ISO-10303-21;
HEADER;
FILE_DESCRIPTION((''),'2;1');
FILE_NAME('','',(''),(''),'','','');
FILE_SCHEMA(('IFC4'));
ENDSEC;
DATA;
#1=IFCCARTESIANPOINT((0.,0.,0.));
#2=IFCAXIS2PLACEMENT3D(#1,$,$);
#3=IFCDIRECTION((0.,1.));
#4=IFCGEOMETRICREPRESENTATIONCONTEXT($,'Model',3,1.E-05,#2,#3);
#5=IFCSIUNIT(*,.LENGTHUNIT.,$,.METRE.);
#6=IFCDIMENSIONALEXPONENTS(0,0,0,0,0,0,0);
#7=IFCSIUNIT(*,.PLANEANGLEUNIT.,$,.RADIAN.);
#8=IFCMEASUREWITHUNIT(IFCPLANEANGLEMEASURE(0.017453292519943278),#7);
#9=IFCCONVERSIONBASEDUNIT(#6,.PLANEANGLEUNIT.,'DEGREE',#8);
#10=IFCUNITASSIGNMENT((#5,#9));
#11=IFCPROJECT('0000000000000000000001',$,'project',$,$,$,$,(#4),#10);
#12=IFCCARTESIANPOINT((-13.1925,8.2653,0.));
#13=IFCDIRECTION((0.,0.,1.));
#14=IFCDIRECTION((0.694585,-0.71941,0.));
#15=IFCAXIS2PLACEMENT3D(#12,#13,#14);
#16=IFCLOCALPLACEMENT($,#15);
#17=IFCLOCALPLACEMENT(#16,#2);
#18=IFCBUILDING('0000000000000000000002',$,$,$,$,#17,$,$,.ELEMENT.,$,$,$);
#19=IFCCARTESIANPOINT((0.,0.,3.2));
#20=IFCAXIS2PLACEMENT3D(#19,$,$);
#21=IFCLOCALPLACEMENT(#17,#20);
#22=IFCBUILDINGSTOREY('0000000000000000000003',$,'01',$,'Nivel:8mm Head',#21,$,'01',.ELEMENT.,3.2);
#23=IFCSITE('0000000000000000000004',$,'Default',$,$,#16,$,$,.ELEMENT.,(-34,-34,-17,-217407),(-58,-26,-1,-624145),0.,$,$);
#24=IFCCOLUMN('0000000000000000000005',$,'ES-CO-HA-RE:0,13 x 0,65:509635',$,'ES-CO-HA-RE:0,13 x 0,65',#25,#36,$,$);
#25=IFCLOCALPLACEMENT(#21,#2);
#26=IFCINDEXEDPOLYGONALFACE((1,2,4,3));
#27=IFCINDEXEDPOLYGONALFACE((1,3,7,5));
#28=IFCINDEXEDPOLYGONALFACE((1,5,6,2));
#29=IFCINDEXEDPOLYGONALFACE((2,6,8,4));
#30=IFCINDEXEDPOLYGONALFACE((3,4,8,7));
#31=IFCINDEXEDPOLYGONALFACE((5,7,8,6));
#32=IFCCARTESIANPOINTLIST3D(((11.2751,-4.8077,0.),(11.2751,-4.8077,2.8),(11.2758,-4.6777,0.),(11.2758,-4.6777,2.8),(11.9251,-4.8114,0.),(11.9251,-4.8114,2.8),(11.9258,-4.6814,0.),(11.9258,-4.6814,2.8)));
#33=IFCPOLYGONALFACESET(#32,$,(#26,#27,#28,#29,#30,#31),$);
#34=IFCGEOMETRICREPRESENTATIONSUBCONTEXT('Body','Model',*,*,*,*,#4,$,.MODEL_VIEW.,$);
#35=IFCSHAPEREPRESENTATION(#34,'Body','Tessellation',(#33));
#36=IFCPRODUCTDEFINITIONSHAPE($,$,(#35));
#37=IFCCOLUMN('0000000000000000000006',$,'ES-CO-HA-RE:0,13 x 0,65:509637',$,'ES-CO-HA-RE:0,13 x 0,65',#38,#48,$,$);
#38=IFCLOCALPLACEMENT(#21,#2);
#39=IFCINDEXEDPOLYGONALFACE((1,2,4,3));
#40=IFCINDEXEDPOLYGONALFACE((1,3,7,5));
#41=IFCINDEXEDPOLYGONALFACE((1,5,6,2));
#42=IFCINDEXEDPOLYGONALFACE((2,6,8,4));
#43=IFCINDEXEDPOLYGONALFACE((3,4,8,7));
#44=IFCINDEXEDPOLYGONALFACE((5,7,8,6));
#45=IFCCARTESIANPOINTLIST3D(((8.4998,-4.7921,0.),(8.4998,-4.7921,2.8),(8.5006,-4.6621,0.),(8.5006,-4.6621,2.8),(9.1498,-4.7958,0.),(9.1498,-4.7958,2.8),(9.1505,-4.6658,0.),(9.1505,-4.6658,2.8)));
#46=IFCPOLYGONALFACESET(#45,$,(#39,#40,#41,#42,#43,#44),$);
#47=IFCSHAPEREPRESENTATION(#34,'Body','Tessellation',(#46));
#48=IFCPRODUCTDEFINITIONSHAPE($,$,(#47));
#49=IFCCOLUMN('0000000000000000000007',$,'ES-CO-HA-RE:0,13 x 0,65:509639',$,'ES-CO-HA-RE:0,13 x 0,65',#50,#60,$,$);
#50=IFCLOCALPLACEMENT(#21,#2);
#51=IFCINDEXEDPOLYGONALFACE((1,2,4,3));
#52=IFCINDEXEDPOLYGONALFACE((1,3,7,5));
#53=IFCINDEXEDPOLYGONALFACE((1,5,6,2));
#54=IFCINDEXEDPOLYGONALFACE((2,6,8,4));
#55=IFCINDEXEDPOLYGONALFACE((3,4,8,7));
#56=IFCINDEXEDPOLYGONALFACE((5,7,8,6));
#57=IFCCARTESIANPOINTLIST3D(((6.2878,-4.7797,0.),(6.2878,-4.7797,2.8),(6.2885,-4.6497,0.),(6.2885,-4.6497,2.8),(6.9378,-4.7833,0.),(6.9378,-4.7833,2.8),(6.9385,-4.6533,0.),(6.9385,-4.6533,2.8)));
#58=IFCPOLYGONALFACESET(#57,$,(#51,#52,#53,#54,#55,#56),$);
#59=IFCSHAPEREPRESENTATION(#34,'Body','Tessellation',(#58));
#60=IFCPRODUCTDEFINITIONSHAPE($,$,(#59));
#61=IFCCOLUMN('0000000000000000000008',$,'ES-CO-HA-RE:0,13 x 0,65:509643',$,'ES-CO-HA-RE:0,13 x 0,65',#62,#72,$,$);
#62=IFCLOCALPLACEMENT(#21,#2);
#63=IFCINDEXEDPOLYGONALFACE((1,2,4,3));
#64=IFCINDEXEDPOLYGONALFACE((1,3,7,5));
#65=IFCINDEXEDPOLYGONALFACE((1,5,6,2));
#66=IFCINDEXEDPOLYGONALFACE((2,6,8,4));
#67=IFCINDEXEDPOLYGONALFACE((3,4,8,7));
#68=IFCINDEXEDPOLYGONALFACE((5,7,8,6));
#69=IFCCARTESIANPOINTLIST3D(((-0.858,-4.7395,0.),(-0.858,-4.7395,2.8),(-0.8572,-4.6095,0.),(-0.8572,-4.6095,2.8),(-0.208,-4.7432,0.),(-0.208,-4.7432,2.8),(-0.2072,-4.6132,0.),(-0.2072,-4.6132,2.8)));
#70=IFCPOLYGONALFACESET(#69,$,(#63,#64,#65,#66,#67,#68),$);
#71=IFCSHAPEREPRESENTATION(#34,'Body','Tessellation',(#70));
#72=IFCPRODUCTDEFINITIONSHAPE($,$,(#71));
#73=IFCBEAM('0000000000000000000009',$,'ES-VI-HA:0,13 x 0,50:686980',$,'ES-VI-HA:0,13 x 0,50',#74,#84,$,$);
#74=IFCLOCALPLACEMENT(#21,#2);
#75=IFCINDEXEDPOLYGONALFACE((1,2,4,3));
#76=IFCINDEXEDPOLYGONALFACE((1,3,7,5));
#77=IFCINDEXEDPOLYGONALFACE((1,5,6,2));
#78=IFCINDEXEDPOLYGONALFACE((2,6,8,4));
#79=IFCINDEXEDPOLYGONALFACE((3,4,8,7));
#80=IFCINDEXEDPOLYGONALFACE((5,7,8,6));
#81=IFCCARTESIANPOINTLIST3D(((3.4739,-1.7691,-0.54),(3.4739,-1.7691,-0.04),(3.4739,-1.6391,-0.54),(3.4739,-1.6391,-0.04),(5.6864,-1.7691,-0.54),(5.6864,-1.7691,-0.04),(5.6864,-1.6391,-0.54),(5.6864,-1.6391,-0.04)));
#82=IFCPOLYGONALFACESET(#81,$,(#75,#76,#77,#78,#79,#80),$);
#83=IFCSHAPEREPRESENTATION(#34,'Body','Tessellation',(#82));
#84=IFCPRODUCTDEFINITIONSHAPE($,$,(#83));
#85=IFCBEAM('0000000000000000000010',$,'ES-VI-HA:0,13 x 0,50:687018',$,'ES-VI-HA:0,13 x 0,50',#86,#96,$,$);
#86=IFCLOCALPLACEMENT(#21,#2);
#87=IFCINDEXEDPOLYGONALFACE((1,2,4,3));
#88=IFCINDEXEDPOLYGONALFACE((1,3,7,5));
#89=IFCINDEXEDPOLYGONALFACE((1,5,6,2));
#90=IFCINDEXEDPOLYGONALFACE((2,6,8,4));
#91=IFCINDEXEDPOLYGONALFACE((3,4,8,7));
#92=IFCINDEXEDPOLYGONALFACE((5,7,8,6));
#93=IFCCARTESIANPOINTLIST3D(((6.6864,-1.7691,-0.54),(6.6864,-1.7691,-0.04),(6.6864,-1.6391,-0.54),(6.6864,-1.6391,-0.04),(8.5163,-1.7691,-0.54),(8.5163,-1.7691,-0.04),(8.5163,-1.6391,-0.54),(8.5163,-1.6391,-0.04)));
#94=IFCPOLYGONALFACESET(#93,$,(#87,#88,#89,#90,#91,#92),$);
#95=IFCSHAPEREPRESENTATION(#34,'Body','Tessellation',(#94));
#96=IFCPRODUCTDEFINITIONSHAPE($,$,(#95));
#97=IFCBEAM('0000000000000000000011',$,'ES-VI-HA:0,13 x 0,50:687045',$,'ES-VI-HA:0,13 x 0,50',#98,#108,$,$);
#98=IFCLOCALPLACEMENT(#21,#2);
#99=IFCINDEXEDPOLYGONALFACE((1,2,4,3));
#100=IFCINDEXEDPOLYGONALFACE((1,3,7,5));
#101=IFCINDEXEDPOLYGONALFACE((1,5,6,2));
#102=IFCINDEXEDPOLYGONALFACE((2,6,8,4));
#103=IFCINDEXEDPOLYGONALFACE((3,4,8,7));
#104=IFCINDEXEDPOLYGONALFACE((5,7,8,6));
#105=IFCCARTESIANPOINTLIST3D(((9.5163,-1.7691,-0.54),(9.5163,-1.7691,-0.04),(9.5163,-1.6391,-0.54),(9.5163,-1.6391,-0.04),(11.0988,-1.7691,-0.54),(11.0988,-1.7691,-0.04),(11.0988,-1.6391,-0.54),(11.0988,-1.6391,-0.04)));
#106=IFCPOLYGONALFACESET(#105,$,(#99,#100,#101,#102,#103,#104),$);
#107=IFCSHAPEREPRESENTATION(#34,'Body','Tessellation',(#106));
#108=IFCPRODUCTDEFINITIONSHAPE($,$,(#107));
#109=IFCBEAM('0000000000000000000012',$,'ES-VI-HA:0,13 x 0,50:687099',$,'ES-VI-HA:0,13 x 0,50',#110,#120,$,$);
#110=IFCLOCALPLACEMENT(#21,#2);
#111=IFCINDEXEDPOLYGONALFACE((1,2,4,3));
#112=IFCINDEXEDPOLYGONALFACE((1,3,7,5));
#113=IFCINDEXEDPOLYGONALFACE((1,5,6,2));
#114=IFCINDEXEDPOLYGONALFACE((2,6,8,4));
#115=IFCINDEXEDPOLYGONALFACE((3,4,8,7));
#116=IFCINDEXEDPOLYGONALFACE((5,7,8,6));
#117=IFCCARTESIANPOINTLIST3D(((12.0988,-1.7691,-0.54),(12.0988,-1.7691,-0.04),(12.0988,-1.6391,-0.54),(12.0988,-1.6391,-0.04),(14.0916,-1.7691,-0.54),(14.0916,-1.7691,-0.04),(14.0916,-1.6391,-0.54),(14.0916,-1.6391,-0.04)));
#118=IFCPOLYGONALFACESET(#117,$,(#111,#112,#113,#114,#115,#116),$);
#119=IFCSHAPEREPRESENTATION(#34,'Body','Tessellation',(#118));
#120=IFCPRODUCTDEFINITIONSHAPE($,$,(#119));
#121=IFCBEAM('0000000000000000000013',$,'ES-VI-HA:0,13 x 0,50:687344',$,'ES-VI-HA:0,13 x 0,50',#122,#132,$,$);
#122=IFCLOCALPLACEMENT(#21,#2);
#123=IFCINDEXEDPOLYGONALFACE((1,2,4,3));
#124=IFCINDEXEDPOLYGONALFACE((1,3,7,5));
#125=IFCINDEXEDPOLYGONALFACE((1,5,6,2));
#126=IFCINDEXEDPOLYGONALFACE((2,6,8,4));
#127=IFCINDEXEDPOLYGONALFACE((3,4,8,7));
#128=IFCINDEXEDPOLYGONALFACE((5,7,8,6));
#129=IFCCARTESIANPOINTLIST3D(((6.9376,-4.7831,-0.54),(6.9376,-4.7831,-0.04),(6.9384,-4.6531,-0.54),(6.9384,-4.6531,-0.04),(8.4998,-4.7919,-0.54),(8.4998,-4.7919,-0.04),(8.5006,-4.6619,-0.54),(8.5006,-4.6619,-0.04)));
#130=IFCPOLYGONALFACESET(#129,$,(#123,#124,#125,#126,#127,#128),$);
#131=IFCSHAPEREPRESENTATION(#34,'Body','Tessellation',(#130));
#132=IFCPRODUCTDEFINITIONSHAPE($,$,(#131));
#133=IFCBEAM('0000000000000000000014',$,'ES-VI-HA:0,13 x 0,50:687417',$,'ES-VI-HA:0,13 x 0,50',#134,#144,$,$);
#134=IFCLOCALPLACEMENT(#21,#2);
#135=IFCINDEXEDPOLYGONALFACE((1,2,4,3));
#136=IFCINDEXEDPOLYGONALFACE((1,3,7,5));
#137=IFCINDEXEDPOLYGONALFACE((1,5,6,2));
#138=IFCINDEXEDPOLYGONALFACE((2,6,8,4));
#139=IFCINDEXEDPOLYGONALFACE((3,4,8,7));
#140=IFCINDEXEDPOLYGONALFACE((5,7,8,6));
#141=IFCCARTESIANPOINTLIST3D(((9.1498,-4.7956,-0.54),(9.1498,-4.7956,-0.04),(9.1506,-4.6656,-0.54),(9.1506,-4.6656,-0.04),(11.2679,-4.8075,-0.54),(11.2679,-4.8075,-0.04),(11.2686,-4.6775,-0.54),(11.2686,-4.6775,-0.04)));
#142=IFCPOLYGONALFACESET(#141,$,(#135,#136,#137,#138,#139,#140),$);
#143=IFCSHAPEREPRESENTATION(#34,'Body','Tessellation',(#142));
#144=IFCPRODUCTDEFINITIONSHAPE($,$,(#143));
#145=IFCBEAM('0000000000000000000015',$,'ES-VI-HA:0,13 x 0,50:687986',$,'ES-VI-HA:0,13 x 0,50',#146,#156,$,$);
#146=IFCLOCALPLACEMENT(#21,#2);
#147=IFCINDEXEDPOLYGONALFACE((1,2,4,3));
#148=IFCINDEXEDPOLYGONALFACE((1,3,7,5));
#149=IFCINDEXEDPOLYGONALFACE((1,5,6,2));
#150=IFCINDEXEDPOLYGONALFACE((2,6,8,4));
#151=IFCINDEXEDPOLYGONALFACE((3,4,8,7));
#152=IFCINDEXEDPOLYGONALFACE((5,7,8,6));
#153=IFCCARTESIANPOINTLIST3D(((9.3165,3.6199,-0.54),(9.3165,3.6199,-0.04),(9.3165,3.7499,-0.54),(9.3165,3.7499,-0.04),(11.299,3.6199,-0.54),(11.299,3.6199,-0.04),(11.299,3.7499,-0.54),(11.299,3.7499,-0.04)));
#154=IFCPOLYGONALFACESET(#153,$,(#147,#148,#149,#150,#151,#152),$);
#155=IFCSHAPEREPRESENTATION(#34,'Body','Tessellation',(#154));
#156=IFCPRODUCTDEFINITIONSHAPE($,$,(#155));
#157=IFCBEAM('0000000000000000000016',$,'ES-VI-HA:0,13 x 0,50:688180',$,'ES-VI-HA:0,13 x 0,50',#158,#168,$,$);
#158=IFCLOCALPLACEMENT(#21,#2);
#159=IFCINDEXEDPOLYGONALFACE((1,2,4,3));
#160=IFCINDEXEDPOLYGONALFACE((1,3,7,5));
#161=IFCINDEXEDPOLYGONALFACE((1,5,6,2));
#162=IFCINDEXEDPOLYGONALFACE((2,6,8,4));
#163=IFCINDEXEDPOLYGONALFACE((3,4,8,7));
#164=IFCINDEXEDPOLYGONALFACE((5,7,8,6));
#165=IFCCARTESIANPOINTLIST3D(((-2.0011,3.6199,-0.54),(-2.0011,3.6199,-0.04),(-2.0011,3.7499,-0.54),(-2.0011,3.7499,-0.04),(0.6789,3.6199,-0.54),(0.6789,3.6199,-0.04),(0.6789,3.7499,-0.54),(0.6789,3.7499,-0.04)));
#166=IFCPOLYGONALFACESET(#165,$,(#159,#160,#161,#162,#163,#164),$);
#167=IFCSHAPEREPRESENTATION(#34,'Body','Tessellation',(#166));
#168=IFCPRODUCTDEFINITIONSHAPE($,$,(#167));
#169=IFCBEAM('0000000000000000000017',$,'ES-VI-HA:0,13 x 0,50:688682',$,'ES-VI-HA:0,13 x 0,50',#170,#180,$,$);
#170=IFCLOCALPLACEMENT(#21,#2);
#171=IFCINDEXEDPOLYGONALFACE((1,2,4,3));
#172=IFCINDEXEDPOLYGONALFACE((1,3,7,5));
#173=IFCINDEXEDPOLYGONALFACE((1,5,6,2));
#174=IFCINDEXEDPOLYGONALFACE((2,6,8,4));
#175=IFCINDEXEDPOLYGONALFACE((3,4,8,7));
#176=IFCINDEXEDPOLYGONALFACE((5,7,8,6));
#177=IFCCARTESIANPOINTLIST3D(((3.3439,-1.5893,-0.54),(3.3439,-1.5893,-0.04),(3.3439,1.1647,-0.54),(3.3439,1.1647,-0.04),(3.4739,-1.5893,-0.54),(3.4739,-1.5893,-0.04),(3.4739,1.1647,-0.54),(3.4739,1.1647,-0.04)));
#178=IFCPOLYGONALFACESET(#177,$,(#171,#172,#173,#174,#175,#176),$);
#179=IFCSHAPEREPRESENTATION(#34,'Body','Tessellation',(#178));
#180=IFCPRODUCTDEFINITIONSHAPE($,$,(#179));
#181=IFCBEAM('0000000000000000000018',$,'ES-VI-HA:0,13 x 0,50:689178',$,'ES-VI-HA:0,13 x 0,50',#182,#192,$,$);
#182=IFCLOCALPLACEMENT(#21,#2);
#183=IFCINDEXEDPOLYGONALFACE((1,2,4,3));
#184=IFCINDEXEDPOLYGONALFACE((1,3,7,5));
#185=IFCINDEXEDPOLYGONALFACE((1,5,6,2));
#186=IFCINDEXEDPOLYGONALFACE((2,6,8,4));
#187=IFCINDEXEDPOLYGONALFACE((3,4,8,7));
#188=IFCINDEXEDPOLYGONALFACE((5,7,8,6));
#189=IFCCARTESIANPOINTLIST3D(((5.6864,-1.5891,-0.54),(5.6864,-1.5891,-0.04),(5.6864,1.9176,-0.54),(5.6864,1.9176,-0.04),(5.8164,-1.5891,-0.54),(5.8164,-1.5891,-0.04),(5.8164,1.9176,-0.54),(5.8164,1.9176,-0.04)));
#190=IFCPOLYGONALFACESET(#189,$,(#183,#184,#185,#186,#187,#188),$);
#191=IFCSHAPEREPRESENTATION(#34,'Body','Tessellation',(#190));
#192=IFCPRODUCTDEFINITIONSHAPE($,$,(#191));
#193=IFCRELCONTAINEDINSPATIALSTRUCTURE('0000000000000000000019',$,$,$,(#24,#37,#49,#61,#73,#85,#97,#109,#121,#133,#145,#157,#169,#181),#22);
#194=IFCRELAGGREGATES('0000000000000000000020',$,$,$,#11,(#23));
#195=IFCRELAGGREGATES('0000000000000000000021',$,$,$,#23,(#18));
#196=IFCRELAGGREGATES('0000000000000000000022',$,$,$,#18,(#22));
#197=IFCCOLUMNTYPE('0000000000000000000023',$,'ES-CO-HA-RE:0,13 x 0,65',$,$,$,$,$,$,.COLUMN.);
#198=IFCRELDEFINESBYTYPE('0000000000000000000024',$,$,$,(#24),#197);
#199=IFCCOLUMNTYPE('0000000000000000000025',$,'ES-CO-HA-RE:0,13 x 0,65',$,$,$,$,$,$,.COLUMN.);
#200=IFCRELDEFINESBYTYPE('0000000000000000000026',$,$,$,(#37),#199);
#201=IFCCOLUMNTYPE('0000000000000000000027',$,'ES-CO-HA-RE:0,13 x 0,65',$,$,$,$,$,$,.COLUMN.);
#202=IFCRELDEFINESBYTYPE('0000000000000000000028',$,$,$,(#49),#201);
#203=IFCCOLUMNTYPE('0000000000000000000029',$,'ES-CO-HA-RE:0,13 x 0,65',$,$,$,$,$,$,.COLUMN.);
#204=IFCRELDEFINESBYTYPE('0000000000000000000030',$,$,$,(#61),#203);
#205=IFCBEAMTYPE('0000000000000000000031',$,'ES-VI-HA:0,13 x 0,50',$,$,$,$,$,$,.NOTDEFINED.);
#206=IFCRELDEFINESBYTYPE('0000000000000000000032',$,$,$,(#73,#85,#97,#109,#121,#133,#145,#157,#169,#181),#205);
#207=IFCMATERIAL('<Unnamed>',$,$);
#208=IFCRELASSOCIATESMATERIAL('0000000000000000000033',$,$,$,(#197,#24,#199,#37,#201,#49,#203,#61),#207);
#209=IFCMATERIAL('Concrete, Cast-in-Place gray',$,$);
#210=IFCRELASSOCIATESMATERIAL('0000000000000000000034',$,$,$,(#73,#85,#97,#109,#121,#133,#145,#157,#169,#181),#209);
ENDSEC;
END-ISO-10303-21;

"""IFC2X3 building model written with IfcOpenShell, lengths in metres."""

from ifc_helpers import new_model, entity, si_unit, converted_unit, direction, frame, frame_2d, origin, origin_2d_with_axis, place, context, subcontext, project, spatial, rectangle, extrude, source, transform, mapped, material, type_object, type_shapes, element, save


model = new_model("IFC2X3")

# Units and contexts
model_context = context("Model", 3, precision=1e-05, world=origin(), true_north=direction((0.0, 1.0)))
body_context = subcontext(model_context, "Body", "Model", "MODEL_VIEW")
ifc_project = project(units=[si_unit("LENGTHUNIT", "METRE"), converted_unit("PLANEANGLEUNIT", "DEGREE", entity("IfcPlaneAngleMeasure", 0.017453292519943278), si_unit("PLANEANGLEUNIT", "RADIAN"), dimensions=[0, 0, 0, 0, 0, 0, 0])], contexts=[model_context])

# Site, building, storey
site_placement = place(None, frame((-13.1925, 8.2653, 0.0), z_axis=(0.0, 0.0, 1.0), x_axis=(0.694585, -0.71941, 0.0)))
site = spatial("IfcSite", under=ifc_project, at=site_placement, Name="Default", CompositionType="ELEMENT", RefLatitude=(-34, -34, -17, -217407), RefLongitude=(-58, -26, -1, -624145), RefElevation=0.0)
building_placement = place(site_placement, origin())
building = spatial("IfcBuilding", under=site, at=building_placement, CompositionType="ELEMENT")
storey_placement = place(building_placement, frame((0.0, 0.0, 3.2)))
storey = spatial("IfcBuildingStorey", under=building, at=storey_placement, Name="01", ObjectType="Nivel:8mm Head", LongName="01", CompositionType="ELEMENT", Elevation=3.2)

# Columns
ifc_material_1 = material(Name="<Unnamed>")
column_type_1 = type_object("IfcColumnType", Name="ES-CO-HA-RE:0,13 x 0,65", PredefinedType="COLUMN", material=ifc_material_1)
shared_shape_1 = source(origin(), body_context, "Body", "SweptSolid", [
    extrude(rectangle(XDim=0.65, YDim=0.13, at=frame_2d((0.0, 0.0), x_axis=(1.0, 0.0))), frame((11.6005, -4.7445, 3.2), z_axis=(0.0, 0.0, 1.0), x_axis=(-0.999984, 0.005619, 0.0)), (0.0, 0.0, 1.0), 2.8),
])
type_shapes(column_type_1, [shared_shape_1])
column_1_placement = place(storey_placement, frame((0.0, 0.0, -3.2)))
element("IfcColumn", 1, at=column_1_placement, inside=storey, type_object=column_type_1, material=ifc_material_1, Name="ES-CO-HA-RE:0,13 x 0,65:509635", ObjectType="ES-CO-HA-RE:0,13 x 0,65", context=body_context, shape_type="MappedRepresentation", body=[
    mapped(shared_shape_1, transform((0.0, 0.0, 0.0), scale=1.0)),
])
column_type_2 = type_object("IfcColumnType", Name="ES-CO-HA-RE:0,13 x 0,65", PredefinedType="COLUMN", material=ifc_material_1)
shared_shape_2 = source(origin(), body_context, "Body", "SweptSolid", [
    extrude(rectangle(XDim=0.65, YDim=0.13, at=origin_2d_with_axis()), frame((8.8252, -4.7289, 3.2), z_axis=(0.0, 0.0, 1.0), x_axis=(-0.999984, 0.005619, 0.0)), (0.0, 0.0, 1.0), 2.8),
])
type_shapes(column_type_2, [shared_shape_2])
column_2_placement = place(storey_placement, frame((0.0, 0.0, -3.2)))
element("IfcColumn", 2, at=column_2_placement, inside=storey, type_object=column_type_2, material=ifc_material_1, Name="ES-CO-HA-RE:0,13 x 0,65:509637", ObjectType="ES-CO-HA-RE:0,13 x 0,65", context=body_context, shape_type="MappedRepresentation", body=[
    mapped(shared_shape_2, transform((0.0, 0.0, 0.0), scale=1.0)),
])
column_type_3 = type_object("IfcColumnType", Name="ES-CO-HA-RE:0,13 x 0,65", PredefinedType="COLUMN", material=ifc_material_1)
shared_shape_3 = source(origin(), body_context, "Body", "SweptSolid", [
    extrude(rectangle(XDim=0.65, YDim=0.13, at=frame_2d((0.0, 0.0), x_axis=(1.0, 0.0))), frame((6.6131, -4.7165, 3.2), z_axis=(0.0, 0.0, 1.0), x_axis=(-0.999984, 0.005619, 0.0)), (0.0, 0.0, 1.0), 2.8),
])
type_shapes(column_type_3, [shared_shape_3])
column_3_placement = place(storey_placement, frame((0.0, 0.0, -3.2)))
element("IfcColumn", 3, at=column_3_placement, inside=storey, type_object=column_type_3, material=ifc_material_1, Name="ES-CO-HA-RE:0,13 x 0,65:509639", ObjectType="ES-CO-HA-RE:0,13 x 0,65", context=body_context, shape_type="MappedRepresentation", body=[
    mapped(shared_shape_3, transform((0.0, 0.0, 0.0), scale=1.0)),
])
column_type_4 = type_object("IfcColumnType", Name="ES-CO-HA-RE:0,13 x 0,65", PredefinedType="COLUMN", material=ifc_material_1)
shared_shape_4 = source(origin(), body_context, "Body", "SweptSolid", [
    extrude(rectangle(XDim=0.65, YDim=0.13, at=frame_2d((0.0, 0.0), x_axis=(1.0, 0.0))), frame((-0.5326, -4.6764, 3.2), z_axis=(0.0, 0.0, 1.0), x_axis=(-0.999984, 0.005619, 0.0)), (0.0, 0.0, 1.0), 2.8),
])
type_shapes(column_type_4, [shared_shape_4])
column_4_placement = place(storey_placement, frame((0.0, 0.0, -3.2)))
element("IfcColumn", 4, at=column_4_placement, inside=storey, type_object=column_type_4, material=ifc_material_1, Name="ES-CO-HA-RE:0,13 x 0,65:509643", ObjectType="ES-CO-HA-RE:0,13 x 0,65", context=body_context, shape_type="MappedRepresentation", body=[
    mapped(shared_shape_4, transform((0.0, 0.0, 0.0), scale=1.0)),
])

# Beams
ifc_material_2 = material(Name="Concrete, Cast-in-Place gray")
beam_type_1 = type_object("IfcBeamType", Name="ES-VI-HA:0,13 x 0,50", PredefinedType="NOTDEFINED")
beam_1_placement = place(storey_placement, frame((2.9074, -1.7041, -0.04)))
element("IfcBeam", 5, at=beam_1_placement, inside=storey, type_object=beam_type_1, material=ifc_material_2, Name="ES-VI-HA:0,13 x 0,50:686980", ObjectType="ES-VI-HA:0,13 x 0,50", context=body_context, shape_type="SweptSolid", body=[
    extrude(rectangle(XDim=0.5, YDim=0.13, at=frame_2d((0.0, 0.0), x_axis=(1.0, 0.0))), frame((0.5665, 0.0, -0.25), z_axis=(1.0, 0.0, 0.0), x_axis=(0.0, 0.0, -1.0)), (0.0, 0.0, 1.0), 2.2125),
])
beam_2_placement = place(storey_placement, frame((5.7373, -1.7041, -0.04)))
element("IfcBeam", 6, at=beam_2_placement, inside=storey, type_object=beam_type_1, material=ifc_material_2, Name="ES-VI-HA:0,13 x 0,50:687018", ObjectType="ES-VI-HA:0,13 x 0,50", context=body_context, shape_type="SweptSolid", body=[
    extrude(rectangle(XDim=0.5, YDim=0.13, at=frame_2d((0.0, 0.0), x_axis=(1.0, 0.0))), frame((0.9491, 0.0, -0.25), z_axis=(1.0, 0.0, 0.0), x_axis=(0.0, 0.0, -1.0)), (0.0, 0.0, 1.0), 1.8299),
])
beam_3_placement = place(storey_placement, frame((8.3198, -1.7041, -0.04)))
element("IfcBeam", 7, at=beam_3_placement, inside=storey, type_object=beam_type_1, material=ifc_material_2, Name="ES-VI-HA:0,13 x 0,50:687045", ObjectType="ES-VI-HA:0,13 x 0,50", context=body_context, shape_type="SweptSolid", body=[
    extrude(rectangle(XDim=0.5, YDim=0.13, at=frame_2d((0.0, 0.0), x_axis=(1.0, 0.0))), frame((1.1965, 0.0, -0.25), z_axis=(1.0, 0.0, 0.0), x_axis=(0.0, 0.0, -1.0)), (0.0, 0.0, 1.0), 1.5825),
])
beam_4_placement = place(storey_placement, frame((11.3129, -1.7041, -0.04)))
element("IfcBeam", 8, at=beam_4_placement, inside=storey, type_object=beam_type_1, material=ifc_material_2, Name="ES-VI-HA:0,13 x 0,50:687099", ObjectType="ES-VI-HA:0,13 x 0,50", context=body_context, shape_type="SweptSolid", body=[
    extrude(rectangle(XDim=0.5, YDim=0.13, at=frame_2d((0.0, 0.0), x_axis=(1.0, 0.0))), frame((0.7858, 0.0, -0.25), z_axis=(1.0, 0.0, 0.0), x_axis=(0.0, 0.0, -1.0)), (0.0, 0.0, 1.0), 1.9928),
])
beam_5_placement = place(storey_placement, frame((6.938, -4.7181, -0.04), z_axis=(0.0, 0.0, 1.0), x_axis=(0.999984, -0.005619, 0.0)))
element("IfcBeam", 9, at=beam_5_placement, inside=storey, type_object=beam_type_1, material=ifc_material_2, Name="ES-VI-HA:0,13 x 0,50:687344", ObjectType="ES-VI-HA:0,13 x 0,50", context=body_context, shape_type="SweptSolid", body=[
    extrude(rectangle(XDim=0.5, YDim=0.13, at=origin_2d_with_axis()), frame((0.0, 0.0, -0.25), z_axis=(1.0, 0.0, 0.0), x_axis=(0.0, 0.0, -1.0)), (0.0, 0.0, 1.0), 1.5622),
])
beam_6_placement = place(storey_placement, frame((9.1483, -4.7305, -0.04), z_axis=(0.0, 0.0, 1.0), x_axis=(0.999984, -0.005619, 0.0)))
element("IfcBeam", 10, at=beam_6_placement, inside=storey, type_object=beam_type_1, material=ifc_material_2, Name="ES-VI-HA:0,13 x 0,50:687417", ObjectType="ES-VI-HA:0,13 x 0,50", context=body_context, shape_type="SweptSolid", body=[
    extrude(rectangle(XDim=0.5, YDim=0.13, at=frame_2d((0.0, 0.0), x_axis=(1.0, 0.0))), frame((0.0019, 0.0, -0.25), z_axis=(1.0, 0.0, 0.0), x_axis=(0.0, 0.0, -1.0)), (0.0, 0.0, 1.0), 2.1181),
])
beam_7_placement = place(storey_placement, frame((9.099, 3.6849, -0.04)))
element("IfcBeam", 11, at=beam_7_placement, inside=storey, type_object=beam_type_1, material=ifc_material_2, Name="ES-VI-HA:0,13 x 0,50:687986", ObjectType="ES-VI-HA:0,13 x 0,50", context=body_context, shape_type="SweptSolid", body=[
    extrude(rectangle(XDim=0.5, YDim=0.13, at=frame_2d((0.0, 0.0), x_axis=(1.0, 0.0))), frame((0.2175, 0.0, -0.25), z_axis=(1.0, 0.0, 0.0), x_axis=(0.0, 0.0, -1.0)), (0.0, 0.0, 1.0), 1.9825),
])
beam_8_placement = place(storey_placement, frame((-2.0011, 3.6849, -0.04)))
element("IfcBeam", 12, at=beam_8_placement, inside=storey, type_object=beam_type_1, material=ifc_material_2, Name="ES-VI-HA:0,13 x 0,50:688180", ObjectType="ES-VI-HA:0,13 x 0,50", context=body_context, shape_type="SweptSolid", body=[
    extrude(rectangle(XDim=0.5, YDim=0.13, at=frame_2d((0.0, 0.0), x_axis=(1.0, 0.0))), frame((0.0, 0.0, -0.25), z_axis=(1.0, 0.0, 0.0), x_axis=(0.0, 0.0, -1.0)), (0.0, 0.0, 1.0), 2.68),
])
beam_9_placement = place(storey_placement, frame((3.4089, -1.5916, -0.04), z_axis=(0.0, 0.0, 1.0), x_axis=(0.0, 1.0, 0.0)))
element("IfcBeam", 13, at=beam_9_placement, inside=storey, type_object=beam_type_1, material=ifc_material_2, Name="ES-VI-HA:0,13 x 0,50:688682", ObjectType="ES-VI-HA:0,13 x 0,50", context=body_context, shape_type="SweptSolid", body=[
    extrude(rectangle(XDim=0.5, YDim=0.13, at=origin_2d_with_axis()), frame((0.0023, 0.0, -0.25), z_axis=(1.0, 0.0, 0.0), x_axis=(0.0, 0.0, -1.0)), (0.0, 0.0, 1.0), 2.7539),
])
beam_10_placement = place(storey_placement, frame((5.7514, -1.5891, -0.04), z_axis=(0.0, 0.0, 1.0), x_axis=(0.0, 1.0, 0.0)))
element("IfcBeam", 14, at=beam_10_placement, inside=storey, type_object=beam_type_1, material=ifc_material_2, Name="ES-VI-HA:0,13 x 0,50:689178", ObjectType="ES-VI-HA:0,13 x 0,50", context=body_context, shape_type="SweptSolid", body=[
    extrude(rectangle(XDim=0.5, YDim=0.13, at=frame_2d((0.0, 0.0), x_axis=(1.0, 0.0))), frame((0.0, 0.0, -0.25), z_axis=(1.0, 0.0, 0.0), x_axis=(0.0, 0.0, -1.0)), (0.0, 0.0, 1.0), 3.5067),
])

save(model, "model.ifc")
